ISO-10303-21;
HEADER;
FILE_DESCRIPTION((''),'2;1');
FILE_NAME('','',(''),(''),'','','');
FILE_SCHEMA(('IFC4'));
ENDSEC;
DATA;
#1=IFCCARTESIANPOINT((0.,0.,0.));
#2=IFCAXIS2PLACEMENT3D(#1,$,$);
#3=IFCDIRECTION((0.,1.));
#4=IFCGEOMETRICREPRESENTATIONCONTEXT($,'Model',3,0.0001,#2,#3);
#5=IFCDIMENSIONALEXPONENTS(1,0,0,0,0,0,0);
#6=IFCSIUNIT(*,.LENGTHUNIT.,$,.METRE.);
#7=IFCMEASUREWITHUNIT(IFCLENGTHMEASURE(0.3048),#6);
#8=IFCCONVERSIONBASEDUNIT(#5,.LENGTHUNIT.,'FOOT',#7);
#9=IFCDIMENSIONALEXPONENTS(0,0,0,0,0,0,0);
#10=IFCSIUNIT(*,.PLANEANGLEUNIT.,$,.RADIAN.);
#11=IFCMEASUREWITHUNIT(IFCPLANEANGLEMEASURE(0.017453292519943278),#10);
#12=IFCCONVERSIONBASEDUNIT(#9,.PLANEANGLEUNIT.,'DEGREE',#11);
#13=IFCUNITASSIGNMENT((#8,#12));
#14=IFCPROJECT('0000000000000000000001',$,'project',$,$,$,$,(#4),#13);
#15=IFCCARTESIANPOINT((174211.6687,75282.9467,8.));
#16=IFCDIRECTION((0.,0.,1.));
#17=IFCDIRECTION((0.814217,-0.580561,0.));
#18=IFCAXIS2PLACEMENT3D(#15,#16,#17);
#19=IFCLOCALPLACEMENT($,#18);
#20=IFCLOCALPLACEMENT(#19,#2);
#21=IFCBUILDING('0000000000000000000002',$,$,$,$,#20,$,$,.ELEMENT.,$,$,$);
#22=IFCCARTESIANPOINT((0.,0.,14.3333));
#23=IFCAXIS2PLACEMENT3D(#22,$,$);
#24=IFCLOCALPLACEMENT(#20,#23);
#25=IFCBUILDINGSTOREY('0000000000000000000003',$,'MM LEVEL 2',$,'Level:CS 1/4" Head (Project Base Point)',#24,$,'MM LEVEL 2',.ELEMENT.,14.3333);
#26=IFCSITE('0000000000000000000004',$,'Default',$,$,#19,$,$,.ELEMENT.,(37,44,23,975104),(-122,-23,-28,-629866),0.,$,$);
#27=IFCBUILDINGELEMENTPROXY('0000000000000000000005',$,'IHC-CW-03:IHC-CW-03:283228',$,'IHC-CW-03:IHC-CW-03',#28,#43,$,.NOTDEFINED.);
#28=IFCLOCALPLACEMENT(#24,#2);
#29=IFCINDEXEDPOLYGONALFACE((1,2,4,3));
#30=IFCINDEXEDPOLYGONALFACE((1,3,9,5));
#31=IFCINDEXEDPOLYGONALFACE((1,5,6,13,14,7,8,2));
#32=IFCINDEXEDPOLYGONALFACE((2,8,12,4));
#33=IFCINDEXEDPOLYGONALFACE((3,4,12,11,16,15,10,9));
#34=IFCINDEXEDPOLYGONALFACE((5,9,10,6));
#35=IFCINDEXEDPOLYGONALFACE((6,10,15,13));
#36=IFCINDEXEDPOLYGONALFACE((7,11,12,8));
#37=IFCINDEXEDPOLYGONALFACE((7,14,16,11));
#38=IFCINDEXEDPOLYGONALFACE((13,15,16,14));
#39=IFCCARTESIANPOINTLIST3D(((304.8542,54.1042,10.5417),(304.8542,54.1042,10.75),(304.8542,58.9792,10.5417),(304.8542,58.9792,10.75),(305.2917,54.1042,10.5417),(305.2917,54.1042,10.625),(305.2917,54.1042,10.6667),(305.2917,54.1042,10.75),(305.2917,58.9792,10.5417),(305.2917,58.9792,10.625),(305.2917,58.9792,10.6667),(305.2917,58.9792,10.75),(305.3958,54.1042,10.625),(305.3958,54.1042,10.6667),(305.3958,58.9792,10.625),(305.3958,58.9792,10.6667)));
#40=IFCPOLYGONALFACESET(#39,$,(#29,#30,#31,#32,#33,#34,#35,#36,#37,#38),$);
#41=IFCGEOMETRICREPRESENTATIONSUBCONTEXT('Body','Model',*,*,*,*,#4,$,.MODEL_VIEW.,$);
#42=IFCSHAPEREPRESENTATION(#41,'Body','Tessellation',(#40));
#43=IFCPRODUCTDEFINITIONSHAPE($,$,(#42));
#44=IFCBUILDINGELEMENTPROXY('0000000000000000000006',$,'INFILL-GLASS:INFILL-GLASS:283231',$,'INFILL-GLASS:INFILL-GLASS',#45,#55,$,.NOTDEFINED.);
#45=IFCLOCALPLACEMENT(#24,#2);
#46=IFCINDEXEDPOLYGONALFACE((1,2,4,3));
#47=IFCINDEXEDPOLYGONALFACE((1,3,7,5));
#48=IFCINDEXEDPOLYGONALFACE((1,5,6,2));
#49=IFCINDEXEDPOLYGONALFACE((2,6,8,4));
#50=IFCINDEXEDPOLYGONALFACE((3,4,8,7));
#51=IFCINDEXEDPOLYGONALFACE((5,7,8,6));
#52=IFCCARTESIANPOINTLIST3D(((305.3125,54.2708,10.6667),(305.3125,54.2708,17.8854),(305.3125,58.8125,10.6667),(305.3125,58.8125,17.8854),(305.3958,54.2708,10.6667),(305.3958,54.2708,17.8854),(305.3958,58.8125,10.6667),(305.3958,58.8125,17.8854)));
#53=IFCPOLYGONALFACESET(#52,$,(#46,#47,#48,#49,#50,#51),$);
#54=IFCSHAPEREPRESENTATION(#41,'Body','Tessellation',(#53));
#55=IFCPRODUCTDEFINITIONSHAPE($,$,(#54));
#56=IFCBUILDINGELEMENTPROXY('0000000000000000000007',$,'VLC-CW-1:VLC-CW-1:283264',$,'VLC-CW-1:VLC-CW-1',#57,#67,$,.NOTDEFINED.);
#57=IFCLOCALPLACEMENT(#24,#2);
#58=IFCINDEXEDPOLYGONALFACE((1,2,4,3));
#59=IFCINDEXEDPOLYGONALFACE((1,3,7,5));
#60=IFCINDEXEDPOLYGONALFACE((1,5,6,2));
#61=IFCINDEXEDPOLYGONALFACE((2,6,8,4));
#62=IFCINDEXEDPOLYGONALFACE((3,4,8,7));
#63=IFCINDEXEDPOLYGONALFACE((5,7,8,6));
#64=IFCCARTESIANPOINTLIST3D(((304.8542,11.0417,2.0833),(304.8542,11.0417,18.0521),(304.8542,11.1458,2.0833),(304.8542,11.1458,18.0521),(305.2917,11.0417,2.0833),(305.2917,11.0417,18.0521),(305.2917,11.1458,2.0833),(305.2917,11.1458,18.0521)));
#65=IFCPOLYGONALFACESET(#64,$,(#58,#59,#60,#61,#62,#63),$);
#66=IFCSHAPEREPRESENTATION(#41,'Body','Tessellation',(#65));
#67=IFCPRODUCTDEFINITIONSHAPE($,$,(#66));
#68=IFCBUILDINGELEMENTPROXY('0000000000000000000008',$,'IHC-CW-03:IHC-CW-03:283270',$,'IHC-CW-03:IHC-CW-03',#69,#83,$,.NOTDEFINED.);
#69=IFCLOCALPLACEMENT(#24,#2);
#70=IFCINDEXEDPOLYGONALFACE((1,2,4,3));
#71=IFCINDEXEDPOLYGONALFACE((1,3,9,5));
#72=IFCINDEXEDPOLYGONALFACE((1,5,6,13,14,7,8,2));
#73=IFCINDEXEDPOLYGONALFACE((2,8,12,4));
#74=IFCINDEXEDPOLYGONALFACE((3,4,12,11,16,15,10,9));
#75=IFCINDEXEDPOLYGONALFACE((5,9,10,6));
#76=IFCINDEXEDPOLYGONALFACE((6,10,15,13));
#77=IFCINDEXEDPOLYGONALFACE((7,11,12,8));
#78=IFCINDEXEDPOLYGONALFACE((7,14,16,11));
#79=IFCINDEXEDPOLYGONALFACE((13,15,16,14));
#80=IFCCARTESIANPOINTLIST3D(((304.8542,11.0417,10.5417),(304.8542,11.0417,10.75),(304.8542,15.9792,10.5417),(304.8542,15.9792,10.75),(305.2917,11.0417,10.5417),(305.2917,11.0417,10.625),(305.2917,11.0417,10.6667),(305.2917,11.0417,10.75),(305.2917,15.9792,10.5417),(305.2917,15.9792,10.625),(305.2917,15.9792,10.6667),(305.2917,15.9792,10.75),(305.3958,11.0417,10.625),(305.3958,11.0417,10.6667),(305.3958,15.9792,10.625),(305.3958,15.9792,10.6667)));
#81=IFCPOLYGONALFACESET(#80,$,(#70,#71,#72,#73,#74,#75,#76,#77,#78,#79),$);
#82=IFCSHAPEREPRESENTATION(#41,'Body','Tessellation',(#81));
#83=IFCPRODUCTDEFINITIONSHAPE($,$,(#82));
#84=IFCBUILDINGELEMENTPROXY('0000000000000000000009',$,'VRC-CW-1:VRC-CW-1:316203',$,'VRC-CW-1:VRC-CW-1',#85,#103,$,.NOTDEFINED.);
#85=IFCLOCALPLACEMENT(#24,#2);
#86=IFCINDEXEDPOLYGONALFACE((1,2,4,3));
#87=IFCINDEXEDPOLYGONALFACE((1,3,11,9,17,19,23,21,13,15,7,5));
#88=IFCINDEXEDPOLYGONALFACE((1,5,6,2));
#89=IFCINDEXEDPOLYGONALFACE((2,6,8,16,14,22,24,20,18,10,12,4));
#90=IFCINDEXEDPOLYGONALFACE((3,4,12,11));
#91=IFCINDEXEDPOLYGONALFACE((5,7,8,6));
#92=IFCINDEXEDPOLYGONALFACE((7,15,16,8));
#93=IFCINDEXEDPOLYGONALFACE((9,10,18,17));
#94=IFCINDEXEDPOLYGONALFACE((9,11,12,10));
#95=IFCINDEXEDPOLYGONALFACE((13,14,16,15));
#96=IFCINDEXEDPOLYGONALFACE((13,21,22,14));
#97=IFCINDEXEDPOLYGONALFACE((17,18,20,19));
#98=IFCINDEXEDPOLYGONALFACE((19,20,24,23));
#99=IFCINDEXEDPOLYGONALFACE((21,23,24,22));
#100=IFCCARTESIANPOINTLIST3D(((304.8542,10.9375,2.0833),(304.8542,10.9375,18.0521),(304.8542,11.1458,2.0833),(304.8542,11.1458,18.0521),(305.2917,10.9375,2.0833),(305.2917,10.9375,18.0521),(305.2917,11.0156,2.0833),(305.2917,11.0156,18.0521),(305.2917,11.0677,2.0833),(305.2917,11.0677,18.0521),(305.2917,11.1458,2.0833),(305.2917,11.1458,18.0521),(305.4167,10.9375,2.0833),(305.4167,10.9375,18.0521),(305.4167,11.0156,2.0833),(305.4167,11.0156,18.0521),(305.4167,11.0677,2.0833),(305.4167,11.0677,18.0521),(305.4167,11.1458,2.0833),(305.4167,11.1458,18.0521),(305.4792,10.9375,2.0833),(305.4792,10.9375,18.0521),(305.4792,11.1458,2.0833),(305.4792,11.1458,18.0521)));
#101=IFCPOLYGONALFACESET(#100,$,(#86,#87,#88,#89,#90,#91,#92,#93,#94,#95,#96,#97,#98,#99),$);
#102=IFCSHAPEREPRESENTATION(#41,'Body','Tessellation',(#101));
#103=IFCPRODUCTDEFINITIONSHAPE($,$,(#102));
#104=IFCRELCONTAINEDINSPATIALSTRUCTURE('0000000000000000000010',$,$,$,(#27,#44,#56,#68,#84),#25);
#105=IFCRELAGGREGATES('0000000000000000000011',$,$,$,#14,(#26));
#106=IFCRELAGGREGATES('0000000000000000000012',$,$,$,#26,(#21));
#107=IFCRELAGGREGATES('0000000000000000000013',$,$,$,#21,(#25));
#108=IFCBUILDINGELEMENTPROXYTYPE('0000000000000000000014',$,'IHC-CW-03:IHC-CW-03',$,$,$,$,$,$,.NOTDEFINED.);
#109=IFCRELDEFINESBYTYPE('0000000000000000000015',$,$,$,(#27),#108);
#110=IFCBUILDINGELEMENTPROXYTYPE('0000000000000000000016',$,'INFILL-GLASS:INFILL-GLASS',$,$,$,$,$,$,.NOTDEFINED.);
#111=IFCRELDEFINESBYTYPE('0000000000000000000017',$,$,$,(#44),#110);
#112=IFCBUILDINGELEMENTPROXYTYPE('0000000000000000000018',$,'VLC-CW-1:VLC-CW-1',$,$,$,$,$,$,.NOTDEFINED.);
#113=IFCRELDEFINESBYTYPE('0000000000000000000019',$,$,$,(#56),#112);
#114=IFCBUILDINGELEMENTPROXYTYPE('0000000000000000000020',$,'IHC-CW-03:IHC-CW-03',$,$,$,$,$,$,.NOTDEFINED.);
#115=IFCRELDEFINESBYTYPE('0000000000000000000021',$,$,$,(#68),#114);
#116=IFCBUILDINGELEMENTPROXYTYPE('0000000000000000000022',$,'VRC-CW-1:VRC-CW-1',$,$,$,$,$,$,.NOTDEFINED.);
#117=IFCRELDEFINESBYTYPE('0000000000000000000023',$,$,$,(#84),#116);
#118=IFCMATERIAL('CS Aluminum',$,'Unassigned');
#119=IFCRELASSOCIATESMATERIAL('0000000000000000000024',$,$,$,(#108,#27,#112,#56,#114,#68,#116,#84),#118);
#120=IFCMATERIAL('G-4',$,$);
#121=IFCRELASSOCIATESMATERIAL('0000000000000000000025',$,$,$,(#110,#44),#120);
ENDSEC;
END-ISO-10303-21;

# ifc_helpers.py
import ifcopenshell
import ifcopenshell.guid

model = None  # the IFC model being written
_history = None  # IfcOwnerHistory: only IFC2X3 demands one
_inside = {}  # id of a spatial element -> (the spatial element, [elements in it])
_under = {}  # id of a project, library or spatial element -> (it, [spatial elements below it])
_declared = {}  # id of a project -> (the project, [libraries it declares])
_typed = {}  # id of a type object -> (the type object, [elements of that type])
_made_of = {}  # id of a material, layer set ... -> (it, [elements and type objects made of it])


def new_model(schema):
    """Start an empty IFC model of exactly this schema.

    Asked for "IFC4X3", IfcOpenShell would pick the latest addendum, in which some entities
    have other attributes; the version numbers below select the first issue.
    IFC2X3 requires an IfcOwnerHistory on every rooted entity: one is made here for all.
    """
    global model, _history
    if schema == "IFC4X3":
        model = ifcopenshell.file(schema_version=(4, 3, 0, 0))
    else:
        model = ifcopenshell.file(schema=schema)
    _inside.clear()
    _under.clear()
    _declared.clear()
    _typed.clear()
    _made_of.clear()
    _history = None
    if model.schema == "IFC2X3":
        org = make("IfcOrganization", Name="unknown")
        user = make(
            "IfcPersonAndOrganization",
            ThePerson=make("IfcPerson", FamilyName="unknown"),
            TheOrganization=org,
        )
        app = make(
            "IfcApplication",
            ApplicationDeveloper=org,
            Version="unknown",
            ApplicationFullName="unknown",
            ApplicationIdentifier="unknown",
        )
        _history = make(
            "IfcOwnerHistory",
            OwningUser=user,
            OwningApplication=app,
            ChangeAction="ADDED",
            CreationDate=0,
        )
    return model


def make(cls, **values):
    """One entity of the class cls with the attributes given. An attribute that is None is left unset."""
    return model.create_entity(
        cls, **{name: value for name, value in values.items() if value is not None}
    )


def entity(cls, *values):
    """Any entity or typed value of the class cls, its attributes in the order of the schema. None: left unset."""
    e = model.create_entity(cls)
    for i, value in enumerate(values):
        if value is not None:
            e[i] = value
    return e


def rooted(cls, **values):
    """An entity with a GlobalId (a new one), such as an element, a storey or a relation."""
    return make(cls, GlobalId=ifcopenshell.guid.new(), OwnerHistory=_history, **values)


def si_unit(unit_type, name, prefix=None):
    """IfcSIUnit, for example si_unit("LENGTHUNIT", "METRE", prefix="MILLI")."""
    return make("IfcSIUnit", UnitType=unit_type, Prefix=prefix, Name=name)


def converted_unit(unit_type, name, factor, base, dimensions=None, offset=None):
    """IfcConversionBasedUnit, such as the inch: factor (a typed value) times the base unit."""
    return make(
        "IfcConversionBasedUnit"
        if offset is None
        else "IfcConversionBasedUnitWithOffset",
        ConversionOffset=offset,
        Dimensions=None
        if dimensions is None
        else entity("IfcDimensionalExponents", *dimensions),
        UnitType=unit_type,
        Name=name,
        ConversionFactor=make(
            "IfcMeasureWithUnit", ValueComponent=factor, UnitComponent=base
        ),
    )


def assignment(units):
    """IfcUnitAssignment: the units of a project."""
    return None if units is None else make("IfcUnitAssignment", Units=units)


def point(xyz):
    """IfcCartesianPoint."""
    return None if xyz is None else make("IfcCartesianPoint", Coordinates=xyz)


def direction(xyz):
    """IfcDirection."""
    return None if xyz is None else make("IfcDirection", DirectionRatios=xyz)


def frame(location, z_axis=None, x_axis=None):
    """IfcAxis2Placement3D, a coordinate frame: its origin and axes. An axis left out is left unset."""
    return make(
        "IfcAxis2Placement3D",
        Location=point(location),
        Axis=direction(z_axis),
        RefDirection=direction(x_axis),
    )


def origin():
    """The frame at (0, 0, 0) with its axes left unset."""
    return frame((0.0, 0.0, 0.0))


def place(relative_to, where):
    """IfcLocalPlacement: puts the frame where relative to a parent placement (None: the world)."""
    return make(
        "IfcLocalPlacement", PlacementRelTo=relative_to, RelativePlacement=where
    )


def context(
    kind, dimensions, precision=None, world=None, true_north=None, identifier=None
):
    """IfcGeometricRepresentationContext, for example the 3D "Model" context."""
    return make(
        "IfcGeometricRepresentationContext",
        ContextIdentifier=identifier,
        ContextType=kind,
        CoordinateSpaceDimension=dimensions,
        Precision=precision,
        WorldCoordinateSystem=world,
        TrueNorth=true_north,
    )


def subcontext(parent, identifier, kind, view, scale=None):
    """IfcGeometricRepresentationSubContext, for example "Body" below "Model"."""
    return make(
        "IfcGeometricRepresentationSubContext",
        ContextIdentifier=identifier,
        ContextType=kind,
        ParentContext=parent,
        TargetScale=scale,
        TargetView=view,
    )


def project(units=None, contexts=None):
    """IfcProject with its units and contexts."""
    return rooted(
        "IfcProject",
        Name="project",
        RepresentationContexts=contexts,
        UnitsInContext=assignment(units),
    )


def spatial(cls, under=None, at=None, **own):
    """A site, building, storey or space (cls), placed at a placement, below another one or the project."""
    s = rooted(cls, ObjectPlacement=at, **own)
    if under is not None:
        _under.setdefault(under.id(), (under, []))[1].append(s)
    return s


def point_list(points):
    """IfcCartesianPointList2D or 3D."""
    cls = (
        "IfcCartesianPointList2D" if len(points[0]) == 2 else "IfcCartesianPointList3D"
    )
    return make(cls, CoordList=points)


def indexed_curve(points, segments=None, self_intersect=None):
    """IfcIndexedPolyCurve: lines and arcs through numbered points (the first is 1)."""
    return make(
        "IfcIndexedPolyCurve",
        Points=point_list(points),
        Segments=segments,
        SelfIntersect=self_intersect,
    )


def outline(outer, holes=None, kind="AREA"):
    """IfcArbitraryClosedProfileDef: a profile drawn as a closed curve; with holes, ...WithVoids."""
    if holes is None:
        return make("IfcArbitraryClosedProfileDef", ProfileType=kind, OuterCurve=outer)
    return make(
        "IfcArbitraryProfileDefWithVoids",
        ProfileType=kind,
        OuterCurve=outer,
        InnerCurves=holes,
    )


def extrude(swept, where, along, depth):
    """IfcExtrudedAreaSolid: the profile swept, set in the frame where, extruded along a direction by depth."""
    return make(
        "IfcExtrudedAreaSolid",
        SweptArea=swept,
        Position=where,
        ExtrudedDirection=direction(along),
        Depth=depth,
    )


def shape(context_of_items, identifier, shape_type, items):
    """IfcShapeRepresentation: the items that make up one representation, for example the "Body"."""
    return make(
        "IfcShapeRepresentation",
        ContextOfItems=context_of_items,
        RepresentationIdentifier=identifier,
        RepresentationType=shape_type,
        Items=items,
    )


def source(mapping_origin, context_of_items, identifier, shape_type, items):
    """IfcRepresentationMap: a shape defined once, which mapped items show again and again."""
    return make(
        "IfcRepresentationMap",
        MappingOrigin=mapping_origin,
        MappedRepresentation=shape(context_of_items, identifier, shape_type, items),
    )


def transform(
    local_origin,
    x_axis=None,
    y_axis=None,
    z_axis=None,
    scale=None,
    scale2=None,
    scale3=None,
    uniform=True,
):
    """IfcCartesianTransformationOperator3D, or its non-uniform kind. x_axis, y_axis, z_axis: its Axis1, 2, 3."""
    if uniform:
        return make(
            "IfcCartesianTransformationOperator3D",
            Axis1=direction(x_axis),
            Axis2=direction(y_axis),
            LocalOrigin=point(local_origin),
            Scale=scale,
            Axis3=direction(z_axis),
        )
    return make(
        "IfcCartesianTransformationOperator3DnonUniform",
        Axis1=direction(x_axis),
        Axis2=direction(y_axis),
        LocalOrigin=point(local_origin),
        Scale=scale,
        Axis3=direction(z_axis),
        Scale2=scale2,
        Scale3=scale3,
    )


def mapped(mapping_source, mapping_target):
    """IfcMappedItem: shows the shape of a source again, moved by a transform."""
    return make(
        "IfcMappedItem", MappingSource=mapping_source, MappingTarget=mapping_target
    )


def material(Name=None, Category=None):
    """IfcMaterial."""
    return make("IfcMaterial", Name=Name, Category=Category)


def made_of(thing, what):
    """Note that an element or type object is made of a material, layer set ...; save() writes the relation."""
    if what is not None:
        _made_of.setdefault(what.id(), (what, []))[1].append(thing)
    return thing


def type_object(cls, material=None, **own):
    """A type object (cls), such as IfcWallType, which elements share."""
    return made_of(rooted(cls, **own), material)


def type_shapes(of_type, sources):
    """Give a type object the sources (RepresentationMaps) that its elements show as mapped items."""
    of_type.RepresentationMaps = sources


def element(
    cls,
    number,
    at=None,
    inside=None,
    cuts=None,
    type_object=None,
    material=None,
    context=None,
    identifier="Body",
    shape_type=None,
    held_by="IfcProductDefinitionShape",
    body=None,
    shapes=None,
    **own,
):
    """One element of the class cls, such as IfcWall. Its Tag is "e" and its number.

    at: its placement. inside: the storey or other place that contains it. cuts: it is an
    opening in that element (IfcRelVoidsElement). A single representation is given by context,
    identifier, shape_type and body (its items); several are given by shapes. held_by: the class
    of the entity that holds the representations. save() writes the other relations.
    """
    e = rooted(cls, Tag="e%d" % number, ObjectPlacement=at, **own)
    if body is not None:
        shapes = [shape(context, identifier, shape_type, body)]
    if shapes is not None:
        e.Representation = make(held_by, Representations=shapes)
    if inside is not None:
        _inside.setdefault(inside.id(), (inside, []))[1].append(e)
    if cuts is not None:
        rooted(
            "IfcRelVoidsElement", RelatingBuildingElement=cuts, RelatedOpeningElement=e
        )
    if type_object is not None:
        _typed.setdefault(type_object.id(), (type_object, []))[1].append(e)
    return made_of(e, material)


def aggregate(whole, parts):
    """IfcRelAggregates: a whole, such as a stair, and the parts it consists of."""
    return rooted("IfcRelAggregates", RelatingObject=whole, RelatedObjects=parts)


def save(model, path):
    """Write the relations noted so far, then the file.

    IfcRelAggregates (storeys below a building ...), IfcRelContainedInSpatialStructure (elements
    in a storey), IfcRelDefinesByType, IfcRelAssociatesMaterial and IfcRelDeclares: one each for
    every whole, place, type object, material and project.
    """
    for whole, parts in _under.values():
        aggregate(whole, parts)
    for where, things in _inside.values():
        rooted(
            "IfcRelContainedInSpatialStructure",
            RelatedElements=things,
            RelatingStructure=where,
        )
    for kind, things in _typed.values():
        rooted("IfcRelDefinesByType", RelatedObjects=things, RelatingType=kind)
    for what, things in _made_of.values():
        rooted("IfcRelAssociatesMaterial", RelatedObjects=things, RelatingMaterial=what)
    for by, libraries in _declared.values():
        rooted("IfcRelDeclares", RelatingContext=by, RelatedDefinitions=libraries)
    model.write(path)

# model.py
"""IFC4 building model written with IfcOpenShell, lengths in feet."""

from ifc_helpers import new_model, entity, si_unit, converted_unit, direction, frame, origin, place, context, subcontext, project, spatial, indexed_curve, outline, extrude, source, transform, mapped, material, type_object, type_shapes, element, save


model = new_model("IFC4")

# Units and contexts
model_context = context("Model", 3, precision=0.0001, world=origin(), true_north=direction((0.0, 1.0)))
body_context = subcontext(model_context, "Body", "Model", "MODEL_VIEW")
ifc_project = project(units=[converted_unit("LENGTHUNIT", "FOOT", entity("IfcLengthMeasure", 0.3048), si_unit("LENGTHUNIT", "METRE"), dimensions=[1, 0, 0, 0, 0, 0, 0]), converted_unit("PLANEANGLEUNIT", "DEGREE", entity("IfcPlaneAngleMeasure", 0.017453292519943278), si_unit("PLANEANGLEUNIT", "RADIAN"), dimensions=[0, 0, 0, 0, 0, 0, 0])], contexts=[model_context])

# Site, building, storey
site_placement = place(None, frame((174211.6687, 75282.9467, 8.0), z_axis=(0.0, 0.0, 1.0), x_axis=(0.814217, -0.580561, 0.0)))
site = spatial("IfcSite", under=ifc_project, at=site_placement, Name="Default", CompositionType="ELEMENT", RefLatitude=(37, 44, 23, 975104), RefLongitude=(-122, -23, -28, -629866), RefElevation=0.0)
building_placement = place(site_placement, origin())
building = spatial("IfcBuilding", under=site, at=building_placement, CompositionType="ELEMENT")
storey_placement = place(building_placement, frame((0.0, 0.0, 14.3333)))
storey = spatial("IfcBuildingStorey", under=building, at=storey_placement, Name="MM LEVEL 2", ObjectType="Level:CS 1/4\" Head (Project Base Point)", LongName="MM LEVEL 2", CompositionType="ELEMENT", Elevation=14.3333)

# Shared definitions
ifc_material_1 = material(Name="CS Aluminum", Category="Unassigned")

# Building element proxies
ifc_material_2 = material(Name="G-4")
building_element_proxy_type_1 = type_object("IfcBuildingElementProxyType", Name="IHC-CW-03:IHC-CW-03", PredefinedType="NOTDEFINED", material=ifc_material_1)
shared_shape_1 = source(origin(), body_context, "Body", "SweptSolid", [
    extrude(outline(indexed_curve([(-0.0208, -0.1875), (0.0208, -0.1875), (0.0208, -0.0833), (0.1042, -0.0833), (0.1042, 0.3542), (-0.1042, 0.3542), (-0.1042, -0.0833), (-0.0208, -0.0833), (-0.0208, -0.1875)], self_intersect=False)), frame((-2.4375, -0.2708, -0.1042), z_axis=(1.0, 0.0, 0.0), x_axis=(0.0, 0.0, 1.0)), (0.0, 0.0, 1.0), 4.875),
])
type_shapes(building_element_proxy_type_1, [shared_shape_1])
proxy_1_placement = place(storey_placement, frame((305.4792, 56.5417, 10.75), z_axis=(0.0, 0.0, 1.0), x_axis=(0.0, -1.0, 0.0)))
element("IfcBuildingElementProxy", 1, at=proxy_1_placement, inside=storey, type_object=building_element_proxy_type_1, material=ifc_material_1, Name="IHC-CW-03:IHC-CW-03:283228", ObjectType="IHC-CW-03:IHC-CW-03", PredefinedType="NOTDEFINED", context=body_context, shape_type="MappedRepresentation", body=[
    mapped(shared_shape_1, transform((0.0, 0.0, 0.0), scale=1.0)),
])
building_element_proxy_type_2 = type_object("IfcBuildingElementProxyType", Name="INFILL-GLASS:INFILL-GLASS", PredefinedType="NOTDEFINED", material=ifc_material_2)
shared_shape_2 = source(origin(), body_context, "Body", "SweptSolid", [
    extrude(outline(indexed_curve([(-0.0417, -2.2708), (0.0417, -2.2708), (0.0417, 2.2708), (-0.0417, 2.2708), (-0.0417, -2.2708)], self_intersect=False)), frame((0.0, 0.125, -0.0833), z_axis=(0.0, 0.0, 1.0), x_axis=(0.0, 1.0, 0.0)), (0.0, 0.0, 1.0), 7.2187),
])
type_shapes(building_element_proxy_type_2, [shared_shape_2])
proxy_2_placement = place(storey_placement, frame((305.4792, 56.5417, 10.75), z_axis=(0.0, 0.0, 1.0), x_axis=(0.0, 1.0, 0.0)))
element("IfcBuildingElementProxy", 2, at=proxy_2_placement, inside=storey, type_object=building_element_proxy_type_2, material=ifc_material_2, Name="INFILL-GLASS:INFILL-GLASS:283231", ObjectType="INFILL-GLASS:INFILL-GLASS", PredefinedType="NOTDEFINED", context=body_context, shape_type="MappedRepresentation", body=[
    mapped(shared_shape_2, transform((0.0, 0.0, 0.0), scale=1.0)),
])
building_element_proxy_type_3 = type_object("IfcBuildingElementProxyType", Name="VLC-CW-1:VLC-CW-1", PredefinedType="NOTDEFINED", material=ifc_material_1)
shared_shape_3 = source(origin(), body_context, "Body", "SweptSolid", [
    extrude(outline(indexed_curve([(-0.2187, -0.0521), (0.2187, -0.0521), (0.2187, 0.0521), (-0.2187, 0.0521), (-0.2187, -0.0521)], self_intersect=False)), frame((0.0521, 0.4062, 0.0), z_axis=(0.0, 0.0, 1.0), x_axis=(0.0, -1.0, 0.0)), (0.0, 0.0, 1.0), 15.9687),
])
type_shapes(building_element_proxy_type_3, [shared_shape_3])
proxy_3_placement = place(storey_placement, frame((305.4792, 11.0417, 2.0833), z_axis=(0.0, 0.0, 1.0), x_axis=(0.0, 1.0, 0.0)))
element("IfcBuildingElementProxy", 3, at=proxy_3_placement, inside=storey, type_object=building_element_proxy_type_3, material=ifc_material_1, Name="VLC-CW-1:VLC-CW-1:283264", ObjectType="VLC-CW-1:VLC-CW-1", PredefinedType="NOTDEFINED", context=body_context, shape_type="MappedRepresentation", body=[
    mapped(shared_shape_3, transform((0.0, 0.0, 0.0), scale=1.0)),
])
building_element_proxy_type_4 = type_object("IfcBuildingElementProxyType", Name="IHC-CW-03:IHC-CW-03", PredefinedType="NOTDEFINED", material=ifc_material_1)
shared_shape_4 = source(origin(), body_context, "Body", "SweptSolid", [
    extrude(outline(indexed_curve([(-0.0208, -0.1875), (0.0208, -0.1875), (0.0208, -0.0833), (0.1042, -0.0833), (0.1042, 0.3542), (-0.1042, 0.3542), (-0.1042, -0.0833), (-0.0208, -0.0833), (-0.0208, -0.1875)], self_intersect=False)), frame((-2.4688, -0.2708, -0.1042), z_axis=(1.0, 0.0, 0.0), x_axis=(0.0, 0.0, 1.0)), (0.0, 0.0, 1.0), 4.9375),
])
type_shapes(building_element_proxy_type_4, [shared_shape_4])
proxy_4_placement = place(storey_placement, frame((305.4792, 13.5104, 10.75), z_axis=(0.0, 0.0, 1.0), x_axis=(0.0, -1.0, 0.0)))
element("IfcBuildingElementProxy", 4, at=proxy_4_placement, inside=storey, type_object=building_element_proxy_type_4, material=ifc_material_1, Name="IHC-CW-03:IHC-CW-03:283270", ObjectType="IHC-CW-03:IHC-CW-03", PredefinedType="NOTDEFINED", context=body_context, shape_type="MappedRepresentation", body=[
    mapped(shared_shape_4, transform((0.0, 0.0, 0.0), scale=1.0)),
])
building_element_proxy_type_5 = type_object("IfcBuildingElementProxyType", Name="VRC-CW-1:VRC-CW-1", PredefinedType="NOTDEFINED", material=ifc_material_1)
shared_shape_5 = source(origin(), body_context, "Body", "SweptSolid", [
    extrude(outline(indexed_curve([(-0.1042, -0.4375), (0.1042, -0.4375), (0.1042, 0.0), (0.0261, 0.0), (0.0261, 0.125), (0.1042, 0.125), (0.1042, 0.1875), (-0.1042, 0.1875), (-0.1042, 0.125), (-0.0261, 0.125), (-0.0261, 0.0), (-0.1042, 0.0), (-0.1042, -0.4375)], self_intersect=False)), frame((0.0, 0.1875, 0.0), z_axis=(0.0, 0.0, 1.0), x_axis=(-1.0, 0.0, 0.0)), (0.0, 0.0, 1.0), 15.9687),
])
type_shapes(building_element_proxy_type_5, [shared_shape_5])
proxy_5_placement = place(storey_placement, frame((305.4792, 11.0417, 2.0833), z_axis=(0.0, 0.0, 1.0), x_axis=(0.0, 1.0, 0.0)))
element("IfcBuildingElementProxy", 5, at=proxy_5_placement, inside=storey, type_object=building_element_proxy_type_5, material=ifc_material_1, Name="VRC-CW-1:VRC-CW-1:316203", ObjectType="VRC-CW-1:VRC-CW-1", PredefinedType="NOTDEFINED", context=body_context, shape_type="MappedRepresentation", body=[
    mapped(shared_shape_5, transform((0.0, 0.0, 0.0), scale=1.0)),
])

save(model, "model.ifc")
